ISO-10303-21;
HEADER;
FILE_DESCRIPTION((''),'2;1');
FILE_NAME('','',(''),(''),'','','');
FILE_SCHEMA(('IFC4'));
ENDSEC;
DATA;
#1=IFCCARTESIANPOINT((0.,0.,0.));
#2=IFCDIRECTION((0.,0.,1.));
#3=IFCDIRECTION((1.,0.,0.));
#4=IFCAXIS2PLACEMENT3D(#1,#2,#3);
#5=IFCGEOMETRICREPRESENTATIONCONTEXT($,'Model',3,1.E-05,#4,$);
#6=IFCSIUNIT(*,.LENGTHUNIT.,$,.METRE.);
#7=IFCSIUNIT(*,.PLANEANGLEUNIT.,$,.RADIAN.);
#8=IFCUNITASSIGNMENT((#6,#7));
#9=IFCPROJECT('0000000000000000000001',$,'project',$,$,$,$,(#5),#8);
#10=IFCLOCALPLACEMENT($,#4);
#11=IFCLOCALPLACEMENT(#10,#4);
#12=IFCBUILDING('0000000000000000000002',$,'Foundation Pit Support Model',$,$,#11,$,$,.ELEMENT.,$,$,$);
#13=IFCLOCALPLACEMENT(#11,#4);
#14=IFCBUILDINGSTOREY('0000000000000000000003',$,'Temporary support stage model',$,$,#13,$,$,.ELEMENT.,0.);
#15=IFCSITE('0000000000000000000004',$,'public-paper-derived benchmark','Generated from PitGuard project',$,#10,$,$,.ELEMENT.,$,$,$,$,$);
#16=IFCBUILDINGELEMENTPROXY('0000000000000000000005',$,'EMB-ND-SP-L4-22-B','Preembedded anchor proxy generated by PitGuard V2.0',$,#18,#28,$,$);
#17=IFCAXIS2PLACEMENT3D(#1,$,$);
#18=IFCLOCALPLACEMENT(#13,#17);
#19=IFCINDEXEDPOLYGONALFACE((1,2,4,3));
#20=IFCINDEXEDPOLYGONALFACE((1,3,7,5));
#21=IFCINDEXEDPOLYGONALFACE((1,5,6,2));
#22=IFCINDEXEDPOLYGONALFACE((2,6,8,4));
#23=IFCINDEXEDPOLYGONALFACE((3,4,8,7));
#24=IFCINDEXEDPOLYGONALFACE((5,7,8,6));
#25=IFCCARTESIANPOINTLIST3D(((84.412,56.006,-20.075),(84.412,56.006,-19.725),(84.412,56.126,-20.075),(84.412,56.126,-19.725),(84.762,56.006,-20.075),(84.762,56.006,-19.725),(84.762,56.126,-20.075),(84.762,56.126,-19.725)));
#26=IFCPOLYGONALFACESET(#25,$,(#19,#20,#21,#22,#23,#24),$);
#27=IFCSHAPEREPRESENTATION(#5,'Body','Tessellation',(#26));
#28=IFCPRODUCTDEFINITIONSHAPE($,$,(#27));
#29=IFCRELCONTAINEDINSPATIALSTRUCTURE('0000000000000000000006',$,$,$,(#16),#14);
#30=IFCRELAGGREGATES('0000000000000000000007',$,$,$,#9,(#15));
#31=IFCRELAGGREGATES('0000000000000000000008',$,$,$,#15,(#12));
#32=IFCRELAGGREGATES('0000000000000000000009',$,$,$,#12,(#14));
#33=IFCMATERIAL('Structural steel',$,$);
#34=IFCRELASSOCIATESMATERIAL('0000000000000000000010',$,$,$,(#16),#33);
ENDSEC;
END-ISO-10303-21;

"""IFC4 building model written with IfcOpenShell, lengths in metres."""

from ifc_helpers import new_model, si_unit, frame, origin_with_axes, origin_2d, place, context, project, spatial, rectangle, extrude, material, element, save


model = new_model("IFC4")

# Units and contexts
model_context = context("Model", 3, precision=1e-05, world=origin_with_axes())
ifc_project = project(units=[si_unit("LENGTHUNIT", "METRE"), si_unit("PLANEANGLEUNIT", "RADIAN")], contexts=[model_context])

# Site, building, storey
site_placement = place(None, origin_with_axes())
site = spatial("IfcSite", under=ifc_project, at=site_placement, Name="public-paper-derived benchmark", Description="Generated from PitGuard project", CompositionType="ELEMENT")
building_placement = place(site_placement, origin_with_axes())
building = spatial("IfcBuilding", under=site, at=building_placement, Name="Foundation Pit Support Model", CompositionType="ELEMENT")
storey_placement = place(building_placement, origin_with_axes())
storey = spatial("IfcBuildingStorey", under=building, at=storey_placement, Name="Temporary support stage model", CompositionType="ELEMENT", Elevation=0.0)

# Shared definitions
ifc_material_1 = material(Name="Structural steel")

# Building element proxy
proxy_1_placement = place(storey_placement, frame((84.587, 56.066, -20.075), z_axis=(0.0, 0.0, 1.0), x_axis=(1.0, 0.0, 0.0)))
element("IfcBuildingElementProxy", 1, at=proxy_1_placement, inside=storey, material=ifc_material_1, Name="EMB-ND-SP-L4-22-B", Description="Preembedded anchor proxy generated by PitGuard V2.0", context=model_context, shape_type="SweptSolid", body=[
    extrude(rectangle(XDim=0.35, YDim=0.12, at=origin_2d()), origin_with_axes(), (0.0, 0.0, 1.0), 0.35),
])

save(model, "model.ifc")
